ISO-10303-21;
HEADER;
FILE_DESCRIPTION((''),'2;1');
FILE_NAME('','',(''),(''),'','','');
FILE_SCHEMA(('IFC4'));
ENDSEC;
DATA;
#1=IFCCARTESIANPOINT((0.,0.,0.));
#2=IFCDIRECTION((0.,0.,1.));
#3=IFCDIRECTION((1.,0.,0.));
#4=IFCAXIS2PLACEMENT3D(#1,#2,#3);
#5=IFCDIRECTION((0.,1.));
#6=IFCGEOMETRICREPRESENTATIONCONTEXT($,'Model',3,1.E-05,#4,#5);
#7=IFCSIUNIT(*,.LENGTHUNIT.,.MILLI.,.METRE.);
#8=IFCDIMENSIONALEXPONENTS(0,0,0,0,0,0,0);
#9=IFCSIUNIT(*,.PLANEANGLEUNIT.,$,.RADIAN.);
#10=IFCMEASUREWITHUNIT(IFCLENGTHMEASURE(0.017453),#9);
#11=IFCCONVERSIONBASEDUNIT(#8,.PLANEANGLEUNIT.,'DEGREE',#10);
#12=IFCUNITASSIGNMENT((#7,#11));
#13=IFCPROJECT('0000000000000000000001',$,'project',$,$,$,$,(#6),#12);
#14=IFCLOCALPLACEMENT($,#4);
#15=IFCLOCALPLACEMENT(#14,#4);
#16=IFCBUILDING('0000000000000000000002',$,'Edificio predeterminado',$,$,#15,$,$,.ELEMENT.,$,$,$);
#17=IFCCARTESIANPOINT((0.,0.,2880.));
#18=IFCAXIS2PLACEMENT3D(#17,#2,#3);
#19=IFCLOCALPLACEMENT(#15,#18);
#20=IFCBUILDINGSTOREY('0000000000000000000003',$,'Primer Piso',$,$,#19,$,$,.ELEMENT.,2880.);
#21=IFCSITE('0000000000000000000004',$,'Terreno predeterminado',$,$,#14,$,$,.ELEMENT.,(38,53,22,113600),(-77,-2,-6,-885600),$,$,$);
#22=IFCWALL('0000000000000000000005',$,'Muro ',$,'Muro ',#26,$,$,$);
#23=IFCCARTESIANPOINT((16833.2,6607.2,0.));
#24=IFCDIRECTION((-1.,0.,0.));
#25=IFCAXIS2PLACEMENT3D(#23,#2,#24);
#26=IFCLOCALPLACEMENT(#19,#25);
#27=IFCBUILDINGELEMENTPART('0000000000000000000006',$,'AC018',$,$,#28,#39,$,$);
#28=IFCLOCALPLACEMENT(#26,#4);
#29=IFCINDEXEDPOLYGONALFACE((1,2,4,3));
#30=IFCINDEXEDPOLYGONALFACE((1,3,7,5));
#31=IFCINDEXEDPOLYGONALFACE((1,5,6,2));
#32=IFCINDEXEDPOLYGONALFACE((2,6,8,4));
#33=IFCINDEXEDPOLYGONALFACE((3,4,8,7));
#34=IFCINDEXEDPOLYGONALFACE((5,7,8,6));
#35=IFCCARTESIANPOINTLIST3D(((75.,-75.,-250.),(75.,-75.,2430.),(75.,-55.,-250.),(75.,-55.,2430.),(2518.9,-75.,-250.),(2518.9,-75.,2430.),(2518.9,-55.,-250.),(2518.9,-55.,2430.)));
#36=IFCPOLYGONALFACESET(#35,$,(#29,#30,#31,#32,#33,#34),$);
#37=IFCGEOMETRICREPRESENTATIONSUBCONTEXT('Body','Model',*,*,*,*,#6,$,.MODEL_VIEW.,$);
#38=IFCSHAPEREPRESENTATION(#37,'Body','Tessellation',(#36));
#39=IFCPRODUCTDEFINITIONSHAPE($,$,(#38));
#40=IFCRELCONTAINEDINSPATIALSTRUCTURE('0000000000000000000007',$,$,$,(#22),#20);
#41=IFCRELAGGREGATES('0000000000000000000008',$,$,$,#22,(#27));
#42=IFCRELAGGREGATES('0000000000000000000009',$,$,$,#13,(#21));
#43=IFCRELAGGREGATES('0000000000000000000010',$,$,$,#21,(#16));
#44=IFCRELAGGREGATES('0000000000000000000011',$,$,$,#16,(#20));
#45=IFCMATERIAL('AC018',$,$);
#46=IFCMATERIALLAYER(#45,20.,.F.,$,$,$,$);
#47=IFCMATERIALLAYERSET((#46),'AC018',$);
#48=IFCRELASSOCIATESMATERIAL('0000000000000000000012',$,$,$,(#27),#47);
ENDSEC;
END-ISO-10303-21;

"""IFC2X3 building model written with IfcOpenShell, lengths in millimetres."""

from ifc_helpers import new_model, entity, si_unit, converted_unit, direction, frame, origin_with_axes, place, context, subcontext, project, spatial, polyline, outline, extrude, material, layer, layer_set, layer_usage, element, aggregate, save


model = new_model("IFC2X3")

# Units and contexts
model_context = context("Model", 3, precision=1e-05, world=origin_with_axes(), true_north=direction((0.0, 1.0)))
body_context = subcontext(model_context, "Body", "Model", "MODEL_VIEW")
ifc_project = project(units=[si_unit("LENGTHUNIT", "METRE", prefix="MILLI"), converted_unit("PLANEANGLEUNIT", "DEGREE", entity("IfcLengthMeasure", 0.017453), si_unit("PLANEANGLEUNIT", "RADIAN"), dimensions=[0, 0, 0, 0, 0, 0, 0])], contexts=[model_context])

# Site, building, storey
site_placement = place(None, origin_with_axes())
site = spatial("IfcSite", under=ifc_project, at=site_placement, Name="Terreno predeterminado", CompositionType="ELEMENT", RefLatitude=(38, 53, 22, 113600), RefLongitude=(-77, -2, -6, -885600))
building_placement = place(site_placement, origin_with_axes())
building = spatial("IfcBuilding", under=site, at=building_placement, Name="Edificio predeterminado", CompositionType="ELEMENT")
storey_placement = place(building_placement, frame((0.0, 0.0, 2880.0), z_axis=(0.0, 0.0, 1.0), x_axis=(1.0, 0.0, 0.0)))
storey = spatial("IfcBuildingStorey", under=building, at=storey_placement, Name="Primer Piso", CompositionType="ELEMENT", Elevation=2880.0)

# Wall, building element part
wall_1_placement = place(storey_placement, frame((16833.2, 6607.2, 0.0), z_axis=(0.0, 0.0, 1.0), x_axis=(-1.0, 0.0, 0.0)))
wall_1 = element("IfcWall", 1, at=wall_1_placement, inside=storey, Name="Muro ", ObjectType="Muro ")
ifc_material_1 = material(Name="AC018")
ifc_layer_1 = layer(ifc_material_1, 20.0, ventilated=False)
ifc_layer_set_1 = layer_set([ifc_layer_1], Name="AC018")
ifc_layer_usage_1 = layer_usage(ifc_layer_set_1, "AXIS2", "NEGATIVE", 55.0)
building_element_part_1_placement = place(wall_1_placement, origin_with_axes())
building_element_part_1 = element("IfcBuildingElementPart", 2, at=building_element_part_1_placement, material=ifc_layer_usage_1, Name="AC018", context=body_context, shape_type="SweptSolid", body=[
    extrude(outline(polyline([(2518.9, -55.0), (2518.9, -75.0), (75.0, -75.0), (75.0, -55.0), (2518.9, -55.0)])), frame((0.0, 0.0, -250.0), z_axis=(0.0, 0.0, 1.0), x_axis=(1.0, 0.0, 0.0)), (0.0, 0.0, 1.0), 2680.0),
])
aggregate(wall_1, [building_element_part_1])

save(model, "model.ifc")
